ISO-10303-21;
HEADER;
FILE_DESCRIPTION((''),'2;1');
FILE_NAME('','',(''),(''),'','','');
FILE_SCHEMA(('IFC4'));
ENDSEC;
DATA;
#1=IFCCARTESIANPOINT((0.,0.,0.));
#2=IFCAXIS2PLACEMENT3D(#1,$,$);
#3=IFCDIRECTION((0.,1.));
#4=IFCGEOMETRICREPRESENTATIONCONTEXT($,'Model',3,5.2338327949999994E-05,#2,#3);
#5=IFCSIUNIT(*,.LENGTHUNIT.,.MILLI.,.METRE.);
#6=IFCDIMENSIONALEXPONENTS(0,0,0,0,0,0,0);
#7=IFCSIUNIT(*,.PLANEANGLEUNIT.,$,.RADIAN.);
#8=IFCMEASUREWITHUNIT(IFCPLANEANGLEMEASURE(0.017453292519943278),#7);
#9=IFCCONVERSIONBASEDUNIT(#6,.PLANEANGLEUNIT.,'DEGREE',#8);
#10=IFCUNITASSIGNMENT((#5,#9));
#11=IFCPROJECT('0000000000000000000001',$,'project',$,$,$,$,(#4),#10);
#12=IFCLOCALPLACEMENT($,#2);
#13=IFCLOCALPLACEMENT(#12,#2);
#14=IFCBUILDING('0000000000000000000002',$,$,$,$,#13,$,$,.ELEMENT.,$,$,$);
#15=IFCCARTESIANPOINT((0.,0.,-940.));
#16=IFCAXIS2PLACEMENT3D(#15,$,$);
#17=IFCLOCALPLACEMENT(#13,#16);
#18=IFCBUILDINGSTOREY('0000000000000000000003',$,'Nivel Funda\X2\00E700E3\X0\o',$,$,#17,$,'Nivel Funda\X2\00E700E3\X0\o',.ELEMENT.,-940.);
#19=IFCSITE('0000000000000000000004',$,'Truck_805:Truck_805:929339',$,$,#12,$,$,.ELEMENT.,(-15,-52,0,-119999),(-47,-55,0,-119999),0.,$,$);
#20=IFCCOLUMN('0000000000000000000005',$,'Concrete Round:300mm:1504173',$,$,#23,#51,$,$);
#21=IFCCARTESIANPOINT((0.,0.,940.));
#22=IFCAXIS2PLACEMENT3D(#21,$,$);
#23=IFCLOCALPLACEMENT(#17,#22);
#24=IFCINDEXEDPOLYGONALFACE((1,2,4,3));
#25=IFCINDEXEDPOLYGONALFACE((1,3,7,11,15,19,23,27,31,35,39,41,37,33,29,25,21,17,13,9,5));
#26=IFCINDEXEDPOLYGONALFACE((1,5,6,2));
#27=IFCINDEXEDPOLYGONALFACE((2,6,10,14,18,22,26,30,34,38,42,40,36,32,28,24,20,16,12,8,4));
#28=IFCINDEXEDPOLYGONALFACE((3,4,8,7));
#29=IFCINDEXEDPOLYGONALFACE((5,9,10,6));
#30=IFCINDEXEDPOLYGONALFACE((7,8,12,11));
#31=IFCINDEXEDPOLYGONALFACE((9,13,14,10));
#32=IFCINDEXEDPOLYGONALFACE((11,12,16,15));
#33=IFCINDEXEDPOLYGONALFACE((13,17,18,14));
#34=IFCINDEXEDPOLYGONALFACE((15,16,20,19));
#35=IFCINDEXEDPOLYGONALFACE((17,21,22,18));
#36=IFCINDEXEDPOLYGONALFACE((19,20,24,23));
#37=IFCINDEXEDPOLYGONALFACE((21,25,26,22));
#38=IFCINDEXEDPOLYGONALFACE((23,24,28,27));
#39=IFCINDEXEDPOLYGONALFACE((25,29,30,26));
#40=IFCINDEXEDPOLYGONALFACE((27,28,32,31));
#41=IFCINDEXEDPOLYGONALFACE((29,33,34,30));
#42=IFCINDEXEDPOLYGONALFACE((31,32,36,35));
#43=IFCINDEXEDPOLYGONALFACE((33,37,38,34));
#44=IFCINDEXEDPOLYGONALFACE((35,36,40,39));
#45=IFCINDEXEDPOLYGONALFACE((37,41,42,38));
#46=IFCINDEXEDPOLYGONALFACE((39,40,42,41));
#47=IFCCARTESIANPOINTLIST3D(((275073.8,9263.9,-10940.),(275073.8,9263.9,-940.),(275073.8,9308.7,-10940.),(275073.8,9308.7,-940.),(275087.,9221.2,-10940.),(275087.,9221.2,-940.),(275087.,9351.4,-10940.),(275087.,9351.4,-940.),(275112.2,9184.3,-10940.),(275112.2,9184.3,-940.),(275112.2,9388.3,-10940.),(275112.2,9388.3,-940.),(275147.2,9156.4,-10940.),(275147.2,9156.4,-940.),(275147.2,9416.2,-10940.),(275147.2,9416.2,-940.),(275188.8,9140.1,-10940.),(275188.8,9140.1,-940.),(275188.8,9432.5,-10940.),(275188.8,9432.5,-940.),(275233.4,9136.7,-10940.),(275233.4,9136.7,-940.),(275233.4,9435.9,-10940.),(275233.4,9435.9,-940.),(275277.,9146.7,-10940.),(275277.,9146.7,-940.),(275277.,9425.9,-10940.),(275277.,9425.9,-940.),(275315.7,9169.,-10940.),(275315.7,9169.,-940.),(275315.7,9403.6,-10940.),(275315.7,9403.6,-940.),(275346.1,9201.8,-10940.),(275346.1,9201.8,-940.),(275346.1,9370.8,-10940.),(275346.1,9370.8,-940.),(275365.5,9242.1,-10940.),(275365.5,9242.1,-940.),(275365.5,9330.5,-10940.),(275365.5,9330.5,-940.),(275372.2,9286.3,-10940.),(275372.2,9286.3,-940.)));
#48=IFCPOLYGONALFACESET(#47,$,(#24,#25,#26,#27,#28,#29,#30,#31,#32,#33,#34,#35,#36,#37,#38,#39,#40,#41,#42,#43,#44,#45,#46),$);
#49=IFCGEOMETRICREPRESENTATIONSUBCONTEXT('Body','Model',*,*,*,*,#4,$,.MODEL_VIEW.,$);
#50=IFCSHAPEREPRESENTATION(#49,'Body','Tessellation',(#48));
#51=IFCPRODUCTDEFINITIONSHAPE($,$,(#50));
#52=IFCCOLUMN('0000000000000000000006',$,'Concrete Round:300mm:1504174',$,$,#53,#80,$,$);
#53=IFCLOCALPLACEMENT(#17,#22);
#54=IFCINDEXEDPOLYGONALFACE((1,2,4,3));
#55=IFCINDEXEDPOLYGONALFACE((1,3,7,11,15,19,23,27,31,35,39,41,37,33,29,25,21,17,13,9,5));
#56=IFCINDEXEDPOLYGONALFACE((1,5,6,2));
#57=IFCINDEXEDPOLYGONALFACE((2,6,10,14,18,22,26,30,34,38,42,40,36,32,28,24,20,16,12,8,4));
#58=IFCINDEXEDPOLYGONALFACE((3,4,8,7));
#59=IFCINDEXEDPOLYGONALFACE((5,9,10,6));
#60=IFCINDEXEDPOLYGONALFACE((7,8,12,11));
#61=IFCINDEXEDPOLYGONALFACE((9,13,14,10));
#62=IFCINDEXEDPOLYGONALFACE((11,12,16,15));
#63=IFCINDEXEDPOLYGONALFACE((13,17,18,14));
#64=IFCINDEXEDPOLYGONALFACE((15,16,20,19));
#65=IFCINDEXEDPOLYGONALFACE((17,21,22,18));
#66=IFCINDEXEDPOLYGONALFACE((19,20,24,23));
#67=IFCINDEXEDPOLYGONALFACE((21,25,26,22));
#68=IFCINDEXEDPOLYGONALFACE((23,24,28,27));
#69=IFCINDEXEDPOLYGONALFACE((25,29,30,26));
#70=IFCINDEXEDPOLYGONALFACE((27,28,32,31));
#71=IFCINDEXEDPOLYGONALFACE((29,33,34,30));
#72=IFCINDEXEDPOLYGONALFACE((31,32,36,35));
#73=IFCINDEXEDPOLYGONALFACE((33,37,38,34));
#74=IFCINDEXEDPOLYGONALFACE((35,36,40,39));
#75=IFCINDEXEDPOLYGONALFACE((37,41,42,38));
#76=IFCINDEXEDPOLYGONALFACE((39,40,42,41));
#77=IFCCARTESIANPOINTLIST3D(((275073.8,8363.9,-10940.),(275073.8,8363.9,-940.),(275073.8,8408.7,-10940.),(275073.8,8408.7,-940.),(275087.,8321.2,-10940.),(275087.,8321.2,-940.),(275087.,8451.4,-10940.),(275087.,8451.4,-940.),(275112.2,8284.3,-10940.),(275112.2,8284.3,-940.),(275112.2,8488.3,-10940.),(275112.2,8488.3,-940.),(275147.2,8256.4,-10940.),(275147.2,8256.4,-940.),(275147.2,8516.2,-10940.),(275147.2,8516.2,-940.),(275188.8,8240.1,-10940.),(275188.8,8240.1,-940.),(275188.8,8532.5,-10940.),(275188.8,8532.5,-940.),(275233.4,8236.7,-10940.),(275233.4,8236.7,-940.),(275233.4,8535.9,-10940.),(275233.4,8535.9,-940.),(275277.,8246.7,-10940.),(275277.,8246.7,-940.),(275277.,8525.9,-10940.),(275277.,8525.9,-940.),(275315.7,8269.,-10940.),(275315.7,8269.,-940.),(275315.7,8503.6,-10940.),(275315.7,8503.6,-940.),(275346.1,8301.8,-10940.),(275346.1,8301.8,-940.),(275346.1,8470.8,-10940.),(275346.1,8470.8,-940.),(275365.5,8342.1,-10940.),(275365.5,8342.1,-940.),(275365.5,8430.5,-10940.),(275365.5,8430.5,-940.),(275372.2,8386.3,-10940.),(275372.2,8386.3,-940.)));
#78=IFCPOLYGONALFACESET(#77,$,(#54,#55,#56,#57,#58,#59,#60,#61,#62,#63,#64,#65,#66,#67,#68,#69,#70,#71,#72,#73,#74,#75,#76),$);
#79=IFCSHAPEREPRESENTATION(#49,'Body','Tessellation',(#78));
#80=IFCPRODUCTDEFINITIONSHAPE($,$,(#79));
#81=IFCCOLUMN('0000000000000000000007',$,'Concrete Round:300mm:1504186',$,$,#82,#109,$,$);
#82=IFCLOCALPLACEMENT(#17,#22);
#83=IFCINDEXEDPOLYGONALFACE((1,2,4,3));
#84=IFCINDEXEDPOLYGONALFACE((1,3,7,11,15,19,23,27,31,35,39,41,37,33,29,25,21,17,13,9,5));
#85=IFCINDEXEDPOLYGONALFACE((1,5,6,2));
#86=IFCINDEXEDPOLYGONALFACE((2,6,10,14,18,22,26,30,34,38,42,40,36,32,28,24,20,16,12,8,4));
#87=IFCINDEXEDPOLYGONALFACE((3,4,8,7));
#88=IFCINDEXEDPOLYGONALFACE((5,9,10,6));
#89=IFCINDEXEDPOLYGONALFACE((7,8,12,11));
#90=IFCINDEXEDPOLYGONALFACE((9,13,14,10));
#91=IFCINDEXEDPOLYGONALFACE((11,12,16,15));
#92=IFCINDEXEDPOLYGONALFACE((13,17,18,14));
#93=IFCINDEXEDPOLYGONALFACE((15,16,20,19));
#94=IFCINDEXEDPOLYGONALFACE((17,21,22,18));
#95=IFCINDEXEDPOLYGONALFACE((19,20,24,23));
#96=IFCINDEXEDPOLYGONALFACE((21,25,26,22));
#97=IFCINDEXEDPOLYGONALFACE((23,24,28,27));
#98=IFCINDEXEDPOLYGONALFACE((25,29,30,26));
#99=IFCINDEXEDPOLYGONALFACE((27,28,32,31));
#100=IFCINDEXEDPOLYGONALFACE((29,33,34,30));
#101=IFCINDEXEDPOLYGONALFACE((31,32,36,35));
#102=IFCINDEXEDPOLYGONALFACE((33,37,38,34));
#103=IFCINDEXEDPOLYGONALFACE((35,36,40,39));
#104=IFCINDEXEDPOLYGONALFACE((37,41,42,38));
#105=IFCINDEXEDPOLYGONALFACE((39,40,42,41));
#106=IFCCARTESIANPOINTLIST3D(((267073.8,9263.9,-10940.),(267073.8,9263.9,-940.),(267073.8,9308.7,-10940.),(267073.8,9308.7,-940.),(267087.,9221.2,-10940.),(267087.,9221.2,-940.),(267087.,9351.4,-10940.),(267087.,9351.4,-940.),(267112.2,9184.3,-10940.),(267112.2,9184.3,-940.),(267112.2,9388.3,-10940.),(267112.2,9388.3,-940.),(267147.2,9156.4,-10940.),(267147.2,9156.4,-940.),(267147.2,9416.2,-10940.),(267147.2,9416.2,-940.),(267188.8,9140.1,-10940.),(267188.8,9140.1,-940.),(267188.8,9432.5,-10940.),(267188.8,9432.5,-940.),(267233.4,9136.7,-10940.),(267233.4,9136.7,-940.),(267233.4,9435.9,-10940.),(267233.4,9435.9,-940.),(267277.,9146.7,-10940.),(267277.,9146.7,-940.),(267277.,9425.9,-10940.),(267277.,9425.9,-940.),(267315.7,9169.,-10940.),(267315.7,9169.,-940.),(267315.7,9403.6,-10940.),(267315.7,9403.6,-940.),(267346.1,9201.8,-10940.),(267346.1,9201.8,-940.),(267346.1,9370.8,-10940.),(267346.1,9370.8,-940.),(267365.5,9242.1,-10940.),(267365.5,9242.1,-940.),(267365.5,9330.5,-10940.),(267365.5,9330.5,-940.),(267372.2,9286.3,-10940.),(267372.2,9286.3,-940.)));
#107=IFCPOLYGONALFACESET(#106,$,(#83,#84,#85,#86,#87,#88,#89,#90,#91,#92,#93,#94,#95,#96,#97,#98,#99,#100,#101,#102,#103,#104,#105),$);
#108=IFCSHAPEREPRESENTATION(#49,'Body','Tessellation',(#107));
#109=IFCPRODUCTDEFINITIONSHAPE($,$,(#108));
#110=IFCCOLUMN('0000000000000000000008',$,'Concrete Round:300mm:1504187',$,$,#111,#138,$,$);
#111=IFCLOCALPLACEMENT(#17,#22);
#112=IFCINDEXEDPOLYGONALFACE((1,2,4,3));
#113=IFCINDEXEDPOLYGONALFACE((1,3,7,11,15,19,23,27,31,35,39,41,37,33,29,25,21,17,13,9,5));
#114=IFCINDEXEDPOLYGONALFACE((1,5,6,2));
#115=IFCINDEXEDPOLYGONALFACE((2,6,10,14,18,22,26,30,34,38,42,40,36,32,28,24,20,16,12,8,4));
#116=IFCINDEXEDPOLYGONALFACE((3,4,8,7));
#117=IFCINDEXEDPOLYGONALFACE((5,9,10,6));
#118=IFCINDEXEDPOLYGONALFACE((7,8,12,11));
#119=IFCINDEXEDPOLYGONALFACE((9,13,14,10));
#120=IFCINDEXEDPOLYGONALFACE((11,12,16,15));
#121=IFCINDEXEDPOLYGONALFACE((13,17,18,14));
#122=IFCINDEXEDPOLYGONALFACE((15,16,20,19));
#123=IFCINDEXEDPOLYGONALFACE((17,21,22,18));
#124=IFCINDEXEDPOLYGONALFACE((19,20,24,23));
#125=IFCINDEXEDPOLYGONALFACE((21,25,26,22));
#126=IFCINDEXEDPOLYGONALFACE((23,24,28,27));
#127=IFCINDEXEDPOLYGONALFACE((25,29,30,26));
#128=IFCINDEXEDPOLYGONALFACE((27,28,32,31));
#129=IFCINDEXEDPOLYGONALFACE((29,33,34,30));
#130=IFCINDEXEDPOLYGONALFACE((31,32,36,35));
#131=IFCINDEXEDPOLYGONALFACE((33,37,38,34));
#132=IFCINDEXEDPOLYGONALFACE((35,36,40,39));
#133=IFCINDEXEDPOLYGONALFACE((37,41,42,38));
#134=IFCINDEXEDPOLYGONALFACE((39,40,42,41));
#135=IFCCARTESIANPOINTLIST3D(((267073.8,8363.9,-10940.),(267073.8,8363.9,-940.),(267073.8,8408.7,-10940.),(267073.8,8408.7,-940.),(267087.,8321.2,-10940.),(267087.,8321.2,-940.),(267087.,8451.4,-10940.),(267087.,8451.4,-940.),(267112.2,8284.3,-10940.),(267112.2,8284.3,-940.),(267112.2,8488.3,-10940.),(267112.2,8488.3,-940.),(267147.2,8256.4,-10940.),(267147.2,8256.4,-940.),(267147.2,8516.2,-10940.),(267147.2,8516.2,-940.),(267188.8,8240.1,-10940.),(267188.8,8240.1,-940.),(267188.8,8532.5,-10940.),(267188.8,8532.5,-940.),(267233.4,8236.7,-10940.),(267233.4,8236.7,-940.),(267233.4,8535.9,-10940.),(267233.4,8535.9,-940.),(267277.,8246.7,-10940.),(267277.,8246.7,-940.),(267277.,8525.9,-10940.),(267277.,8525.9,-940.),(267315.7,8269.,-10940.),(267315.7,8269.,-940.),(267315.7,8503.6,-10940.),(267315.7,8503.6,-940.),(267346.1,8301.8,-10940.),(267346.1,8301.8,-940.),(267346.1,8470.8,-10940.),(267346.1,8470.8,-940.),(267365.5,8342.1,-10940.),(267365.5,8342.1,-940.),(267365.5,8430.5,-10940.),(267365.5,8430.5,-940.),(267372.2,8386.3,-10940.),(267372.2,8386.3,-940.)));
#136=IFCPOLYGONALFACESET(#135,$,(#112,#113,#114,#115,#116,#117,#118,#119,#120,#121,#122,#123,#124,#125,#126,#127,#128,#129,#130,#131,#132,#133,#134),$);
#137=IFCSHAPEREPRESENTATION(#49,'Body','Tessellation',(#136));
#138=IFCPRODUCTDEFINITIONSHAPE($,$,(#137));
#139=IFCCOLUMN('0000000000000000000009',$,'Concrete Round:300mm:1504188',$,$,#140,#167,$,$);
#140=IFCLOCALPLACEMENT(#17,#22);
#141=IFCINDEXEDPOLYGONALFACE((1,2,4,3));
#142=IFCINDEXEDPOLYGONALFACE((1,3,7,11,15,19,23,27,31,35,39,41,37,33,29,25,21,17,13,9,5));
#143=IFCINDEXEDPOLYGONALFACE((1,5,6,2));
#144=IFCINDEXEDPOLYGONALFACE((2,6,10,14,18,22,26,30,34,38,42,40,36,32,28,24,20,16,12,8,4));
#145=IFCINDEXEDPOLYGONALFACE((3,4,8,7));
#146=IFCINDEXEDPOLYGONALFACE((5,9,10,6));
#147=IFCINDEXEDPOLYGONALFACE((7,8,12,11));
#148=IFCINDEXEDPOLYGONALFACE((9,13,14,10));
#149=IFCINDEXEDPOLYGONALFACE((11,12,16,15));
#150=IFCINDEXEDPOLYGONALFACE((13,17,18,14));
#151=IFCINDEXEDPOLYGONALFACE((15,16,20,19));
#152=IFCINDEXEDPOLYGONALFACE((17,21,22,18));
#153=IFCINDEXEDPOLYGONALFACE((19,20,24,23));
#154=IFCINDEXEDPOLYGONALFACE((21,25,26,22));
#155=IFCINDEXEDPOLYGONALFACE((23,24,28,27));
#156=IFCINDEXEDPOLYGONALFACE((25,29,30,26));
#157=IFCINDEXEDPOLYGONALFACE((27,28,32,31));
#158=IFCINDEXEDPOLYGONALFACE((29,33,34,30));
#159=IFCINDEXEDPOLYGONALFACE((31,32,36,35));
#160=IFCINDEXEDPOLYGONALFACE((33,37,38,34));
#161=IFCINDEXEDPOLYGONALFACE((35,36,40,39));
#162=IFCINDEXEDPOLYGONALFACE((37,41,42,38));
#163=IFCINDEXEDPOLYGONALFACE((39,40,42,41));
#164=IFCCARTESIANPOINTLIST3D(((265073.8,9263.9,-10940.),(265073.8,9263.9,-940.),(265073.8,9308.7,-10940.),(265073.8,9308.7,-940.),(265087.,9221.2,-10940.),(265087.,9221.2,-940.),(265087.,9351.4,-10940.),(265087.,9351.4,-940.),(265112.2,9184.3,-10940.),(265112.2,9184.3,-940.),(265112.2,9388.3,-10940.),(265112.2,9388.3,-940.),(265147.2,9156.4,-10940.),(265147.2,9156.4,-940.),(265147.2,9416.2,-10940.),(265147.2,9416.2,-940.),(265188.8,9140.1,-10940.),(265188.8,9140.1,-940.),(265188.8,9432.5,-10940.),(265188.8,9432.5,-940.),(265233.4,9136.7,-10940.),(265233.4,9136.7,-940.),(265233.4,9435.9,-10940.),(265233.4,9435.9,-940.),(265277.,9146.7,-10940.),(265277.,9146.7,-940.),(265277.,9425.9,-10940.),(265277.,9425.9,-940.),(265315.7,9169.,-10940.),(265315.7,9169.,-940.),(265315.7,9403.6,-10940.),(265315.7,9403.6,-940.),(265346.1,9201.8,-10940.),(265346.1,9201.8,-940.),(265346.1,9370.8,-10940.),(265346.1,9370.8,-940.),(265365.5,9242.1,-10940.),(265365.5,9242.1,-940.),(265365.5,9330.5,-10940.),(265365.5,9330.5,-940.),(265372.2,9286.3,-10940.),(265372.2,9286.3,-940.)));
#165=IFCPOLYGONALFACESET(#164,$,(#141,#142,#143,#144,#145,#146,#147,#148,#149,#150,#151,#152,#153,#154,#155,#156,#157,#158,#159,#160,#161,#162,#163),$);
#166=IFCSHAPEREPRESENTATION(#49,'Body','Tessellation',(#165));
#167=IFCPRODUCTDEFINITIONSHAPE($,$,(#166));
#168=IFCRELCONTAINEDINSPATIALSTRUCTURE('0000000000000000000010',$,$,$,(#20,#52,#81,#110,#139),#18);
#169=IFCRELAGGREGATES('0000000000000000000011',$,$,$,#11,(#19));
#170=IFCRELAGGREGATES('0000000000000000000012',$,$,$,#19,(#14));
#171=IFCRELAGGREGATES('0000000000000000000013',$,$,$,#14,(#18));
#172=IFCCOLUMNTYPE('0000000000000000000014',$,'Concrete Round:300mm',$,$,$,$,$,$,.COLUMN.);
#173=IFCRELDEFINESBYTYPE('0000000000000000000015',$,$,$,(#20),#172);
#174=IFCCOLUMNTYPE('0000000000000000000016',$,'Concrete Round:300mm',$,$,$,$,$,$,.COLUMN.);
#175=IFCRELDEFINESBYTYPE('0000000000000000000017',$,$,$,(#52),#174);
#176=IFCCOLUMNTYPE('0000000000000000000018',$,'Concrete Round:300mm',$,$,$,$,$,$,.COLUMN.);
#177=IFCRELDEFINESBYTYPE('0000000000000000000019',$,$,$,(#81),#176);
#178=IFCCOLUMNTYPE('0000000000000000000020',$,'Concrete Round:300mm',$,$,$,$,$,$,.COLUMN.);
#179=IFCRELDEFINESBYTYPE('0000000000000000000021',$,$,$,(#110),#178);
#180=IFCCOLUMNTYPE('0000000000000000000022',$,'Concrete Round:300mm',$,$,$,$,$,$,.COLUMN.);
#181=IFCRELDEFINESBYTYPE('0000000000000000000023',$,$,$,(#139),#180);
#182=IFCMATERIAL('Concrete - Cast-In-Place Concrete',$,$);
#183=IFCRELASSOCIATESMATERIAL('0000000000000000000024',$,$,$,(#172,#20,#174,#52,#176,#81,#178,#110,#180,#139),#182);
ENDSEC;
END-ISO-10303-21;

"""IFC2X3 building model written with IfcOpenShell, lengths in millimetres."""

from ifc_helpers import new_model, entity, si_unit, converted_unit, direction, frame, origin, origin_2d_with_axis, place, context, subcontext, project, spatial, circle, extrude, source, transform, mapped, material, type_object, type_shapes, element, save


model = new_model("IFC2X3")

# Units and contexts
model_context = context("Model", 3, precision=5.2338327949999994e-05, world=origin(), true_north=direction((0.0, 1.0)))
body_context = subcontext(model_context, "Body", "Model", "MODEL_VIEW")
ifc_project = project(units=[si_unit("LENGTHUNIT", "METRE", prefix="MILLI"), converted_unit("PLANEANGLEUNIT", "DEGREE", entity("IfcPlaneAngleMeasure", 0.017453292519943278), si_unit("PLANEANGLEUNIT", "RADIAN"), dimensions=[0, 0, 0, 0, 0, 0, 0])], contexts=[model_context])

# Site, building, storey
site_placement = place(None, origin())
site = spatial("IfcSite", under=ifc_project, at=site_placement, Name="Truck_805:Truck_805:929339", CompositionType="ELEMENT", RefLatitude=(-15, -52, 0, -119999), RefLongitude=(-47, -55, 0, -119999), RefElevation=0.0)
building_placement = place(site_placement, origin())
building = spatial("IfcBuilding", under=site, at=building_placement, CompositionType="ELEMENT")
storey_placement = place(building_placement, frame((0.0, 0.0, -940.0)))
storey = spatial("IfcBuildingStorey", under=building, at=storey_placement, Name="Nivel Fundação", LongName="Nivel Fundação", CompositionType="ELEMENT", Elevation=-940.0)

# Columns
ifc_material = material(Name="Concrete - Cast-In-Place Concrete")
column_type_1 = type_object("IfcColumnType", Name="Concrete Round:300mm", PredefinedType="COLUMN", material=ifc_material)
shared_shape_1 = source(origin(), body_context, "Body", "SweptSolid", [
    extrude(circle(Radius=150.0, at=origin_2d_with_axis()), frame((275222.2, 9286.3, -10940.0)), (0.0, 0.0, 1.0), 10000.0),
])
type_shapes(column_type_1, [shared_shape_1])
column_1_placement = place(storey_placement, frame((0.0, 0.0, 940.0)))
element("IfcColumn", 1, at=column_1_placement, inside=storey, type_object=column_type_1, material=ifc_material, Name="Concrete Round:300mm:1504173", context=body_context, shape_type="MappedRepresentation", body=[
    mapped(shared_shape_1, transform((0.0, 0.0, 0.0), scale=1.0)),
])
column_type_2 = type_object("IfcColumnType", Name="Concrete Round:300mm", PredefinedType="COLUMN", material=ifc_material)
shared_shape_2 = source(origin(), body_context, "Body", "SweptSolid", [
    extrude(circle(Radius=150.0, at=origin_2d_with_axis()), frame((275222.2, 8386.3, -10940.0)), (0.0, 0.0, 1.0), 10000.0),
])
type_shapes(column_type_2, [shared_shape_2])
column_2_placement = place(storey_placement, frame((0.0, 0.0, 940.0)))
element("IfcColumn", 2, at=column_2_placement, inside=storey, type_object=column_type_2, material=ifc_material, Name="Concrete Round:300mm:1504174", context=body_context, shape_type="MappedRepresentation", body=[
    mapped(shared_shape_2, transform((0.0, 0.0, 0.0), scale=1.0)),
])
column_type_3 = type_object("IfcColumnType", Name="Concrete Round:300mm", PredefinedType="COLUMN", material=ifc_material)
shared_shape_3 = source(origin(), body_context, "Body", "SweptSolid", [
    extrude(circle(Radius=150.0, at=origin_2d_with_axis()), frame((267222.2, 9286.3, -10940.0)), (0.0, 0.0, 1.0), 10000.0),
])
type_shapes(column_type_3, [shared_shape_3])
column_3_placement = place(storey_placement, frame((0.0, 0.0, 940.0)))
element("IfcColumn", 3, at=column_3_placement, inside=storey, type_object=column_type_3, material=ifc_material, Name="Concrete Round:300mm:1504186", context=body_context, shape_type="MappedRepresentation", body=[
    mapped(shared_shape_3, transform((0.0, 0.0, 0.0), scale=1.0)),
])
column_type_4 = type_object("IfcColumnType", Name="Concrete Round:300mm", PredefinedType="COLUMN", material=ifc_material)
shared_shape_4 = source(origin(), body_context, "Body", "SweptSolid", [
    extrude(circle(Radius=150.0, at=origin_2d_with_axis()), frame((267222.2, 8386.3, -10940.0)), (0.0, 0.0, 1.0), 10000.0),
])
type_shapes(column_type_4, [shared_shape_4])
column_4_placement = place(storey_placement, frame((0.0, 0.0, 940.0)))
element("IfcColumn", 4, at=column_4_placement, inside=storey, type_object=column_type_4, material=ifc_material, Name="Concrete Round:300mm:1504187", context=body_context, shape_type="MappedRepresentation", body=[
    mapped(shared_shape_4, transform((0.0, 0.0, 0.0), scale=1.0)),
])
column_type_5 = type_object("IfcColumnType", Name="Concrete Round:300mm", PredefinedType="COLUMN", material=ifc_material)
shared_shape_5 = source(origin(), body_context, "Body", "SweptSolid", [
    extrude(circle(Radius=150.0, at=origin_2d_with_axis()), frame((265222.2, 9286.3, -10940.0)), (0.0, 0.0, 1.0), 10000.0),
])
type_shapes(column_type_5, [shared_shape_5])
column_5_placement = place(storey_placement, frame((0.0, 0.0, 940.0)))
element("IfcColumn", 5, at=column_5_placement, inside=storey, type_object=column_type_5, material=ifc_material, Name="Concrete Round:300mm:1504188", context=body_context, shape_type="MappedRepresentation", body=[
    mapped(shared_shape_5, transform((0.0, 0.0, 0.0), scale=1.0)),
])

save(model, "model.ifc")
